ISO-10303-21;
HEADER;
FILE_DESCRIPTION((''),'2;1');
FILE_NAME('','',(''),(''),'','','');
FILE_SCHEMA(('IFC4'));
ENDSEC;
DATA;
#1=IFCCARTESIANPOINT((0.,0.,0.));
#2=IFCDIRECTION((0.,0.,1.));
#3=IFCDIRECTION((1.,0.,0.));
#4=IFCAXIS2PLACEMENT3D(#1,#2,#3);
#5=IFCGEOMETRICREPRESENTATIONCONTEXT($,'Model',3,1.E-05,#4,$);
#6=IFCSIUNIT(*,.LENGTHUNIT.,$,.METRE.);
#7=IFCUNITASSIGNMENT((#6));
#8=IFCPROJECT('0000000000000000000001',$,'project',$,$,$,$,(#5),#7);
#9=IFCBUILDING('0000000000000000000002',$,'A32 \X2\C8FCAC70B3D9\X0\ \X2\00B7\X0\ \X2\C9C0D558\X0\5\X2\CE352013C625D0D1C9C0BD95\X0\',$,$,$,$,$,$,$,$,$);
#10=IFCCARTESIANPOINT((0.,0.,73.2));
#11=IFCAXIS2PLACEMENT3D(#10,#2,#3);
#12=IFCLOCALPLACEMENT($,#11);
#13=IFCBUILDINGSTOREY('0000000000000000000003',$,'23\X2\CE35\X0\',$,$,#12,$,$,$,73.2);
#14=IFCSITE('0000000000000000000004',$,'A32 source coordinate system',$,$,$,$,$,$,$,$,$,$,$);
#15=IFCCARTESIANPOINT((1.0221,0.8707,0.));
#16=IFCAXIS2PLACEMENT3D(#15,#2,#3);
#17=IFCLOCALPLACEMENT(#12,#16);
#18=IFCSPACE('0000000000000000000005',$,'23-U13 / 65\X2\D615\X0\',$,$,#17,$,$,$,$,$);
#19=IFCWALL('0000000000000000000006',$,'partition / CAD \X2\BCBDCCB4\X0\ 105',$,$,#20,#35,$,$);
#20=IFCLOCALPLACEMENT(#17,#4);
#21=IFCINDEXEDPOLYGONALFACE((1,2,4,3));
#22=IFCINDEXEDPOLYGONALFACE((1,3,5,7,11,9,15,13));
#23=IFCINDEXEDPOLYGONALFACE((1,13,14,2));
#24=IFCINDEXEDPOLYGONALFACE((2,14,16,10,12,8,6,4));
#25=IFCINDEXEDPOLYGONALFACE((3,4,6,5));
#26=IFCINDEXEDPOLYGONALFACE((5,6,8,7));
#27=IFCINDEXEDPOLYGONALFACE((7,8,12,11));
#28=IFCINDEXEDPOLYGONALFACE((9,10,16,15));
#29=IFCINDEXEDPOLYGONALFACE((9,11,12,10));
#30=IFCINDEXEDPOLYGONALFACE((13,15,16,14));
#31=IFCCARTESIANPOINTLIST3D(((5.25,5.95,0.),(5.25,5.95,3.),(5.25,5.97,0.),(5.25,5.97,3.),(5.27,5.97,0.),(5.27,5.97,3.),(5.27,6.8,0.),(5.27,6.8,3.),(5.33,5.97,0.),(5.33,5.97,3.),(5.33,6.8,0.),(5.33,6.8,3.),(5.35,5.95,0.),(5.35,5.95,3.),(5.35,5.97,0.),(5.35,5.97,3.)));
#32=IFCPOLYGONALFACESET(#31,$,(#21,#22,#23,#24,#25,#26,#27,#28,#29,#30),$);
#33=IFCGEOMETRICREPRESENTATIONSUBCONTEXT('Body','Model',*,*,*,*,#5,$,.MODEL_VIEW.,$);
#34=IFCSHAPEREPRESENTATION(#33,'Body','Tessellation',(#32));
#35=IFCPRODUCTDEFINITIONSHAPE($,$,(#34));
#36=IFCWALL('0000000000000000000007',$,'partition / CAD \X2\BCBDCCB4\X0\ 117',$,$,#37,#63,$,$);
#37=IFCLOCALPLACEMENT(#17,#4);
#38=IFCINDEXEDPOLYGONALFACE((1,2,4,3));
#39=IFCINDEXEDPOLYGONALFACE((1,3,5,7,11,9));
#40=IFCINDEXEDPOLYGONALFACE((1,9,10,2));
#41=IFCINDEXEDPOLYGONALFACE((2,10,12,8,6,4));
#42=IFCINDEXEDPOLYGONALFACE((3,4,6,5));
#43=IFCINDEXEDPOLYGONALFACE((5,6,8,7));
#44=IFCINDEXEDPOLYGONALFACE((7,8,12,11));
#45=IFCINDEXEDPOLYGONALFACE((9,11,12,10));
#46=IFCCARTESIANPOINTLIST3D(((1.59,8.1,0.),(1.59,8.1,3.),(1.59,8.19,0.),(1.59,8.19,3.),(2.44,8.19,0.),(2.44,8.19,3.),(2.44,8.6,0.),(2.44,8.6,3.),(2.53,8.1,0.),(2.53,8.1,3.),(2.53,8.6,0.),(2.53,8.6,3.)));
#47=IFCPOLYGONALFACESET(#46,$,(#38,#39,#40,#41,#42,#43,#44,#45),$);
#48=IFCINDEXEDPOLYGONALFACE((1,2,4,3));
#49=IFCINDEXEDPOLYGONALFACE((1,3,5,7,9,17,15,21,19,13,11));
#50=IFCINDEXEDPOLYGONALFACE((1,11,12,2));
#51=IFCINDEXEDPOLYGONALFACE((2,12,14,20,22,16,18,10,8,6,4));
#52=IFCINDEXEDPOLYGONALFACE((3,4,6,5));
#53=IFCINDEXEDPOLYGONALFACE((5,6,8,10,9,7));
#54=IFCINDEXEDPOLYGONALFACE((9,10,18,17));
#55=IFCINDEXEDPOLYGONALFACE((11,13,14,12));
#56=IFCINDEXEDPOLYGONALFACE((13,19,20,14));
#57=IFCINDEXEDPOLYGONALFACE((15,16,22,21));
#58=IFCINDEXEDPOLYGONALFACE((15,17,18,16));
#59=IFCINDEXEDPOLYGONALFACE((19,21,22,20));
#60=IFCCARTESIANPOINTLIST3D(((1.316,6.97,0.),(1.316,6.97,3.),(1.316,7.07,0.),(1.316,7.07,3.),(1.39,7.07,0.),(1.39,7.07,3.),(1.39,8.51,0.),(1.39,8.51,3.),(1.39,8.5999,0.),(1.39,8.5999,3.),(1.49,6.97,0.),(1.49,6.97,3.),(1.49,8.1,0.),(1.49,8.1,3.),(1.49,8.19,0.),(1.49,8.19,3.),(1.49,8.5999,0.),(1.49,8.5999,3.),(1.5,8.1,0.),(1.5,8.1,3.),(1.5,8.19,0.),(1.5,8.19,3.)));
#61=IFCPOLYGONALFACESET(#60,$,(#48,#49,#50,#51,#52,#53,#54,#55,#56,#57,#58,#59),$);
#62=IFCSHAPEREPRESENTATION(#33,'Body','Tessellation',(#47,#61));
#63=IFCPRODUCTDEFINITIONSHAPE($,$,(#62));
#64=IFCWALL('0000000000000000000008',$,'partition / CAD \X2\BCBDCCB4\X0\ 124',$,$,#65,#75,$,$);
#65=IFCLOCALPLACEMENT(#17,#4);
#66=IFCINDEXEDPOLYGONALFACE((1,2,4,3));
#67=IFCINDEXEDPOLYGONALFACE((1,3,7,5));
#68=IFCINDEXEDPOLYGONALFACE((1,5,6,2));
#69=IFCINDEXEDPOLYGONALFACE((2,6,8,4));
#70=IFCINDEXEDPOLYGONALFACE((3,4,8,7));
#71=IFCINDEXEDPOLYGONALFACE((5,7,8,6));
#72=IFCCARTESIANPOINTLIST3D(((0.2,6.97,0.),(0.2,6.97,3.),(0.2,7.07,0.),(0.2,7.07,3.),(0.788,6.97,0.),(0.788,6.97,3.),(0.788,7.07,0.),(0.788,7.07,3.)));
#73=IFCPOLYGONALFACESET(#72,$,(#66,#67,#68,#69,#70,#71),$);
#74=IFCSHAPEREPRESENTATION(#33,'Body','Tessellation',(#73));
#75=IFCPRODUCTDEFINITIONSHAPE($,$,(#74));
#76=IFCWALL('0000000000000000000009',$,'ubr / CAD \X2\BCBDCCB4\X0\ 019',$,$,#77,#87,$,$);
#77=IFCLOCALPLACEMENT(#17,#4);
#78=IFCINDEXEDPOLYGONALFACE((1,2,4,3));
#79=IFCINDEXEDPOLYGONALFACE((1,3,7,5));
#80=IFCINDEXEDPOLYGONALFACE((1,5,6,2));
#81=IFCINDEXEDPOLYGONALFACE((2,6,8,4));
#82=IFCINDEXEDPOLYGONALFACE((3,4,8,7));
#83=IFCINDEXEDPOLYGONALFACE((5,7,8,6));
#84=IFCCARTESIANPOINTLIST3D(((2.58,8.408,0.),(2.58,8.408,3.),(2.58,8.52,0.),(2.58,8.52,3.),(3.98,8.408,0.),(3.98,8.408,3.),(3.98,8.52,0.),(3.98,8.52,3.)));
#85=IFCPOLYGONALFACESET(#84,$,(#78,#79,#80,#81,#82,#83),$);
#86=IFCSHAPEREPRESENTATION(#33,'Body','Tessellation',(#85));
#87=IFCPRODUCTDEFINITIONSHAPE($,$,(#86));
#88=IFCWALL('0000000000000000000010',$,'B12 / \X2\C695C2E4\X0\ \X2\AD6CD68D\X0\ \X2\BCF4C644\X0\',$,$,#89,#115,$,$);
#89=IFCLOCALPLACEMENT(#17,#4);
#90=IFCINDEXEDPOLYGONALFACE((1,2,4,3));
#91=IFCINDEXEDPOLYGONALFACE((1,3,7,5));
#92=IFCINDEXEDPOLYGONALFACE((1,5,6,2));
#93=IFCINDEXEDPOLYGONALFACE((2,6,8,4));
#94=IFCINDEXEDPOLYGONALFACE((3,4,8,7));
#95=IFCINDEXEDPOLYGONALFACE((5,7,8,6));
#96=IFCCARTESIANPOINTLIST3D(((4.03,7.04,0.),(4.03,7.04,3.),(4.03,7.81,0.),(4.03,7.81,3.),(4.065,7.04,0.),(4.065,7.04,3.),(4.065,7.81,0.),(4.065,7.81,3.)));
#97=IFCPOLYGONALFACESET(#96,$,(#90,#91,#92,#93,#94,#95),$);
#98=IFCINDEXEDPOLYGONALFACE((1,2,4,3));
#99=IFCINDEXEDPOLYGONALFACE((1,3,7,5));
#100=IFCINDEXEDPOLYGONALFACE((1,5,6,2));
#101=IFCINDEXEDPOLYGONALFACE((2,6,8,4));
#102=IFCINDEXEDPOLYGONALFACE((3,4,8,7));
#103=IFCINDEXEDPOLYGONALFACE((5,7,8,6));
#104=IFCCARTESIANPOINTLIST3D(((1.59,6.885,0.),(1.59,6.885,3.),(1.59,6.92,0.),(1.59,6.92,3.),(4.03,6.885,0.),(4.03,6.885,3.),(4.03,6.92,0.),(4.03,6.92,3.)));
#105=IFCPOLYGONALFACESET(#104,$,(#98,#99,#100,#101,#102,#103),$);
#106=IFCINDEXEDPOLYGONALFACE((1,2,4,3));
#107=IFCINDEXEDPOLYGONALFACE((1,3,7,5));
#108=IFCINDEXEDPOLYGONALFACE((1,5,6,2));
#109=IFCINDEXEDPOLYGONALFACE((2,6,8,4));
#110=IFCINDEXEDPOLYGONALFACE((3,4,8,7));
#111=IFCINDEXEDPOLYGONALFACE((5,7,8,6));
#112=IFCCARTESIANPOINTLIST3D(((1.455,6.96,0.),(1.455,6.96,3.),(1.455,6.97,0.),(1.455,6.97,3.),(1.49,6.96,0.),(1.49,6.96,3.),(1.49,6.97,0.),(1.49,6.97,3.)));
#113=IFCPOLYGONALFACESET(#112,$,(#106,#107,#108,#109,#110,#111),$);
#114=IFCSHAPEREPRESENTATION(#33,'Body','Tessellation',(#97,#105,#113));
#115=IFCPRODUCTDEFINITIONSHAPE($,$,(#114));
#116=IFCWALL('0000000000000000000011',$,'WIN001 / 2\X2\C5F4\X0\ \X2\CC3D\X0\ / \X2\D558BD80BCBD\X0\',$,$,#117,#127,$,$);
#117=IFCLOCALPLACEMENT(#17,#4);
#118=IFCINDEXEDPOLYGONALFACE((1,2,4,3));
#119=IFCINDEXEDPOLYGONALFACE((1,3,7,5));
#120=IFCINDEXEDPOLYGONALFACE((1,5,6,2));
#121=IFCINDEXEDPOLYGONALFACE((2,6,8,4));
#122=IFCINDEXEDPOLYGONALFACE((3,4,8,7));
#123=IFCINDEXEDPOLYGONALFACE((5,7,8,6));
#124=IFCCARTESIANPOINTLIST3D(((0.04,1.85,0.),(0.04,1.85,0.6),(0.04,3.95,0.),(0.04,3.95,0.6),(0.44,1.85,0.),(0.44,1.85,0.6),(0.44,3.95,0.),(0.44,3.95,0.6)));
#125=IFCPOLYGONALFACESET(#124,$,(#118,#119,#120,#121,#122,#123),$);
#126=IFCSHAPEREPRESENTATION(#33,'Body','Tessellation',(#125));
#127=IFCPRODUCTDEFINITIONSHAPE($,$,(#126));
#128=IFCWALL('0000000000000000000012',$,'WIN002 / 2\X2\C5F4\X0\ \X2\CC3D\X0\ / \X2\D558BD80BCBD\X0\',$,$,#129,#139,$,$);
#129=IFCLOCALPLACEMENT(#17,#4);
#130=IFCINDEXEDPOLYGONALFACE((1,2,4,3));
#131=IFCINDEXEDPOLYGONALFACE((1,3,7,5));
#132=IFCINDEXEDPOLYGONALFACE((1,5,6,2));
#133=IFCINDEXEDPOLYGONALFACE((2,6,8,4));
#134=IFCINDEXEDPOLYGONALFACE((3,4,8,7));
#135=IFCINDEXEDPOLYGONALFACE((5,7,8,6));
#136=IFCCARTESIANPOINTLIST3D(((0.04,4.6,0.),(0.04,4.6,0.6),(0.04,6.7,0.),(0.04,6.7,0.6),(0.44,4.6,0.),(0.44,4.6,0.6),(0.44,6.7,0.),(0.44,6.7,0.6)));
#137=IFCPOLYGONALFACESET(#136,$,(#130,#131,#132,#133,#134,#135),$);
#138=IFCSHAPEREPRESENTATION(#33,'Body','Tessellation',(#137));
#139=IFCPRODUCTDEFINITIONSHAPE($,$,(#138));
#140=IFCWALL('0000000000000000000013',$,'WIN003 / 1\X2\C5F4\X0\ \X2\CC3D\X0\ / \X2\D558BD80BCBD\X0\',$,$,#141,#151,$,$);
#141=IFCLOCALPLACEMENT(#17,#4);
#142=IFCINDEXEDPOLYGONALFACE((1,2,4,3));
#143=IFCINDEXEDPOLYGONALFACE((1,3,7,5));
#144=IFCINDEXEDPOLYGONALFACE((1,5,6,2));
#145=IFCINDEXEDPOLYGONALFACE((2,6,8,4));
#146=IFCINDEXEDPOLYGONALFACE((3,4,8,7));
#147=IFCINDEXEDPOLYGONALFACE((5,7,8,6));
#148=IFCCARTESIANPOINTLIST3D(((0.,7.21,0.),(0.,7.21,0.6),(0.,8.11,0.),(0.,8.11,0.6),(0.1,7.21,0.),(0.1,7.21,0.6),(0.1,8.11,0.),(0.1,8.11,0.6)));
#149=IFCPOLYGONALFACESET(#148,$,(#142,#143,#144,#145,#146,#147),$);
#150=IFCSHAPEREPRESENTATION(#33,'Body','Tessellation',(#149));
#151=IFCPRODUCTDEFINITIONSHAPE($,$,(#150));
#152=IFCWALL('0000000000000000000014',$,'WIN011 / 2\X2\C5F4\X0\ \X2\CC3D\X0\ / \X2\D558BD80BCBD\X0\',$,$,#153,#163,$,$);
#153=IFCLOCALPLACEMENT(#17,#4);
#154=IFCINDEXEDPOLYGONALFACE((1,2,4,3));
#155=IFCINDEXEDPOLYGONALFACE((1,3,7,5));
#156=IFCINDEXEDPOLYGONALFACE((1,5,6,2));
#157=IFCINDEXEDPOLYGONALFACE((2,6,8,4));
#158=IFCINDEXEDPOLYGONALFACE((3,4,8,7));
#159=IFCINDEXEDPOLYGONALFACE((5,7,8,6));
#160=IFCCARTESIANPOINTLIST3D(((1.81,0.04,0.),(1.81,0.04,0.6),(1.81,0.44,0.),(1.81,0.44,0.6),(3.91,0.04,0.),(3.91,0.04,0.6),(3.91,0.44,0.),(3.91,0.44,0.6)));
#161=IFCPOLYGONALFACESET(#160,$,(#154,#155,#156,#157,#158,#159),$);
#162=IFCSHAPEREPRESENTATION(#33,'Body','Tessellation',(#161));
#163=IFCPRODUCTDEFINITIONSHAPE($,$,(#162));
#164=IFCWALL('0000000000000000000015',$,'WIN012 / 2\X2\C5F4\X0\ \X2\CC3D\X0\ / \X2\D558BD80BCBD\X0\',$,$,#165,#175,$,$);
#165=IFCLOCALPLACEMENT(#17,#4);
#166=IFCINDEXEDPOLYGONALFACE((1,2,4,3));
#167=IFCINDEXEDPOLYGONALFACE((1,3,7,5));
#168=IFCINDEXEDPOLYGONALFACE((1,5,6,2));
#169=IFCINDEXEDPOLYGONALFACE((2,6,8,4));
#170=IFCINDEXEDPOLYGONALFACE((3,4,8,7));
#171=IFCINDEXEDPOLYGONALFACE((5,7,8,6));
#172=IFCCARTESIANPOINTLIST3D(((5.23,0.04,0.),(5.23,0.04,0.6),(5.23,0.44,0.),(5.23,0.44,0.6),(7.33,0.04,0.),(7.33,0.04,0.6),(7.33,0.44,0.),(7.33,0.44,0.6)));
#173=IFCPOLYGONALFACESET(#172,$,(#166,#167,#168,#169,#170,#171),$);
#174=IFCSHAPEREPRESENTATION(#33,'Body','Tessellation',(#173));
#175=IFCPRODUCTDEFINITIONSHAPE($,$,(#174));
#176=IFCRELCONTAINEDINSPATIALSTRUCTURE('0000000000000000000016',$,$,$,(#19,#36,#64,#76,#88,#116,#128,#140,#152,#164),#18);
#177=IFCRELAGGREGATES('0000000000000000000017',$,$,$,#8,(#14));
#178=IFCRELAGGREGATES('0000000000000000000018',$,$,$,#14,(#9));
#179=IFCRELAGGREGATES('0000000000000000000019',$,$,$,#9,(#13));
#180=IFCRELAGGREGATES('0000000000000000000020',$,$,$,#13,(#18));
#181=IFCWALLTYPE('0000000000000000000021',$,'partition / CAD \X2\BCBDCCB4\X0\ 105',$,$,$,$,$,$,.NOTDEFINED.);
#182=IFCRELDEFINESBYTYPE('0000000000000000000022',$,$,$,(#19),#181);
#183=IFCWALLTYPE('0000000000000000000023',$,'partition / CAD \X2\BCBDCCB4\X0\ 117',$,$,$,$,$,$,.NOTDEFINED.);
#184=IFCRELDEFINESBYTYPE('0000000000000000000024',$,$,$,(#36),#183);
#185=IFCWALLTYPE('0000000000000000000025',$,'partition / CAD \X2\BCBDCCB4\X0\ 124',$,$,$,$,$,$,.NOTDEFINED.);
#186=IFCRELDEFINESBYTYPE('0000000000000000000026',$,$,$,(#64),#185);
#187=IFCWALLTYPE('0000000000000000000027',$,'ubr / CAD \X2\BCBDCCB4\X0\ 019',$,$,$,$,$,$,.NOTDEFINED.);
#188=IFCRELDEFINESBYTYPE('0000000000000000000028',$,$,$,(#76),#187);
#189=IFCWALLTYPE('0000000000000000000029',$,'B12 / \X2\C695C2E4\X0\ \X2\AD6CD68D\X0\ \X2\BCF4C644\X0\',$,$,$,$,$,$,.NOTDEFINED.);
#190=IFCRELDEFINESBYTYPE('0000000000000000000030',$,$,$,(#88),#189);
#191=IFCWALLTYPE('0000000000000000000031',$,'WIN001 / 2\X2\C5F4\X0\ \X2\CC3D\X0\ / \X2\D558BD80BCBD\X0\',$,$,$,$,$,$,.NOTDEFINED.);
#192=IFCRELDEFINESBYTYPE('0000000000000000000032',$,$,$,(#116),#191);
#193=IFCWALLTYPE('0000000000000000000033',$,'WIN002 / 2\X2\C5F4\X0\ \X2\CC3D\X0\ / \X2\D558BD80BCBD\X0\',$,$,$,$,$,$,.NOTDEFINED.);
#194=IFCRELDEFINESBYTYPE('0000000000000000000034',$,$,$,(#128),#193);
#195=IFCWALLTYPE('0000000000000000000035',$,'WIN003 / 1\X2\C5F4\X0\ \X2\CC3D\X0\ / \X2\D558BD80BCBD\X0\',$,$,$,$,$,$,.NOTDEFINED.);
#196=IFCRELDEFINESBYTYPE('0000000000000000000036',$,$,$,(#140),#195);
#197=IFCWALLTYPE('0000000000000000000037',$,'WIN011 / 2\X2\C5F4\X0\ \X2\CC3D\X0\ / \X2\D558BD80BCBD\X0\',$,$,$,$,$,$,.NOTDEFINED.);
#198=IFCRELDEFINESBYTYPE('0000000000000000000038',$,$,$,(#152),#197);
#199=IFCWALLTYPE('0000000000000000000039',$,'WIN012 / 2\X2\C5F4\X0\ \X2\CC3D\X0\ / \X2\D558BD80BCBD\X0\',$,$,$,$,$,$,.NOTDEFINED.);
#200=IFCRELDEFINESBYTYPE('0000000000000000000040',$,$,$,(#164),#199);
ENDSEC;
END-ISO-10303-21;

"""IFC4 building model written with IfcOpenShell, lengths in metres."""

from ifc_helpers import new_model, si_unit, frame, origin, origin_with_axes, place, context, subcontext, project, spatial, polyline, outline, extrude, source, transform, mapped, type_object, type_shapes, element, save


model = new_model("IFC4")

# Units and contexts
model_context = context("Model", 3, precision=1e-05, world=origin_with_axes())
body_context = subcontext(model_context, "Body", "Model", "MODEL_VIEW")
ifc_project = project(units=[si_unit("LENGTHUNIT", "METRE")], contexts=[model_context])

# Site, building, storey, space
site = spatial("IfcSite", under=ifc_project, Name="A32 source coordinate system")
building = spatial("IfcBuilding", under=site, Name="A32 주거동 · 지하5층–옥탑지붕")
storey_placement = place(None, frame((0.0, 0.0, 73.2), z_axis=(0.0, 0.0, 1.0), x_axis=(1.0, 0.0, 0.0)))
storey = spatial("IfcBuildingStorey", under=building, at=storey_placement, Name="23층", Elevation=73.2)
space_placement = place(storey_placement, frame((1.0221, 0.8707, 0.0), z_axis=(0.0, 0.0, 1.0), x_axis=(1.0, 0.0, 0.0)))
space = spatial("IfcSpace", under=storey, at=space_placement, Name="23-U13 / 65형")

# Walls
wall_type_1 = type_object("IfcWallType", Name="partition / CAD 벽체 105", PredefinedType="NOTDEFINED")
shared_shape_1 = source(origin(), body_context, "Body", "SweptSolid", [
    extrude(outline(polyline([(5.25, 5.97), (5.27, 5.97), (5.27, 6.8), (5.33, 6.8), (5.33, 5.97), (5.35, 5.97), (5.35, 5.95), (5.25, 5.95), (5.25, 5.97)])), origin(), (0.0, 0.0, 1.0), 3.0),
])
type_shapes(wall_type_1, [shared_shape_1])
wall_1_placement = place(space_placement, origin_with_axes())
element("IfcWall", 1, at=wall_1_placement, inside=space, type_object=wall_type_1, Name="partition / CAD 벽체 105", context=body_context, shape_type="MappedRepresentation", body=[
    mapped(shared_shape_1, transform((0.0, 0.0, 0.0), scale=1.0)),
])
wall_type_2 = type_object("IfcWallType", Name="partition / CAD 벽체 117", PredefinedType="NOTDEFINED")
shared_shape_2 = source(origin(), body_context, "Body", "SweptSolid", [
    extrude(outline(polyline([(2.53, 8.1), (1.59, 8.1), (1.59, 8.19), (2.44, 8.19), (2.44, 8.6), (2.53, 8.6), (2.53, 8.1)])), origin(), (0.0, 0.0, 1.0), 3.0),
    extrude(outline(polyline([(1.49, 8.1), (1.49, 6.97), (1.316, 6.97), (1.316, 7.07), (1.39, 7.07), (1.39, 8.51), (1.39, 8.5999), (1.49, 8.5999), (1.49, 8.19), (1.5, 8.19), (1.5, 8.1), (1.49, 8.1)])), origin(), (0.0, 0.0, 1.0), 3.0),
])
type_shapes(wall_type_2, [shared_shape_2])
wall_2_placement = place(space_placement, origin_with_axes())
element("IfcWall", 2, at=wall_2_placement, inside=space, type_object=wall_type_2, Name="partition / CAD 벽체 117", context=body_context, shape_type="MappedRepresentation", body=[
    mapped(shared_shape_2, transform((0.0, 0.0, 0.0), scale=1.0)),
])
wall_type_3 = type_object("IfcWallType", Name="partition / CAD 벽체 124", PredefinedType="NOTDEFINED")
shared_shape_3 = source(origin(), body_context, "Body", "SweptSolid", [
    extrude(outline(polyline([(0.788, 7.07), (0.788, 6.97), (0.2, 6.97), (0.2, 7.07), (0.788, 7.07)])), origin(), (0.0, 0.0, 1.0), 3.0),
])
type_shapes(wall_type_3, [shared_shape_3])
wall_3_placement = place(space_placement, origin_with_axes())
element("IfcWall", 3, at=wall_3_placement, inside=space, type_object=wall_type_3, Name="partition / CAD 벽체 124", context=body_context, shape_type="MappedRepresentation", body=[
    mapped(shared_shape_3, transform((0.0, 0.0, 0.0), scale=1.0)),
])
wall_type_4 = type_object("IfcWallType", Name="ubr / CAD 벽체 019", PredefinedType="NOTDEFINED")
shared_shape_4 = source(origin(), body_context, "Body", "SweptSolid", [
    extrude(outline(polyline([(3.98, 8.408), (2.58, 8.408), (2.58, 8.52), (3.98, 8.52), (3.98, 8.408)])), origin(), (0.0, 0.0, 1.0), 3.0),
])
type_shapes(wall_type_4, [shared_shape_4])
wall_4_placement = place(space_placement, origin_with_axes())
element("IfcWall", 4, at=wall_4_placement, inside=space, type_object=wall_type_4, Name="ubr / CAD 벽체 019", context=body_context, shape_type="MappedRepresentation", body=[
    mapped(shared_shape_4, transform((0.0, 0.0, 0.0), scale=1.0)),
])
wall_type_5 = type_object("IfcWallType", Name="B12 / 욕실 구획 보완", PredefinedType="NOTDEFINED")
shared_shape_5 = source(origin(), body_context, "Body", "SweptSolid", [
    extrude(outline(polyline([(4.065, 7.04), (4.03, 7.04), (4.03, 7.81), (4.065, 7.81), (4.065, 7.04)])), origin(), (0.0, 0.0, 1.0), 3.0),
    extrude(outline(polyline([(1.59, 6.92), (4.03, 6.92), (4.03, 6.885), (1.59, 6.885), (1.59, 6.92)])), origin(), (0.0, 0.0, 1.0), 3.0),
    extrude(outline(polyline([(1.455, 6.97), (1.49, 6.97), (1.49, 6.96), (1.455, 6.96), (1.455, 6.97)])), origin(), (0.0, 0.0, 1.0), 3.0),
])
type_shapes(wall_type_5, [shared_shape_5])
wall_5_placement = place(space_placement, origin_with_axes())
element("IfcWall", 5, at=wall_5_placement, inside=space, type_object=wall_type_5, Name="B12 / 욕실 구획 보완", context=body_context, shape_type="MappedRepresentation", body=[
    mapped(shared_shape_5, transform((0.0, 0.0, 0.0), scale=1.0)),
])
wall_type_6 = type_object("IfcWallType", Name="WIN001 / 2열 창 / 하부벽", PredefinedType="NOTDEFINED")
shared_shape_6 = source(origin(), body_context, "Body", "SweptSolid", [
    extrude(outline(polyline([(0.04, 3.95), (0.44, 3.95), (0.44, 1.85), (0.04, 1.85), (0.04, 3.95)])), origin(), (0.0, 0.0, 1.0), 0.6),
])
type_shapes(wall_type_6, [shared_shape_6])
wall_6_placement = place(space_placement, origin_with_axes())
element("IfcWall", 6, at=wall_6_placement, inside=space, type_object=wall_type_6, Name="WIN001 / 2열 창 / 하부벽", context=body_context, shape_type="MappedRepresentation", body=[
    mapped(shared_shape_6, transform((0.0, 0.0, 0.0), scale=1.0)),
])
wall_type_7 = type_object("IfcWallType", Name="WIN002 / 2열 창 / 하부벽", PredefinedType="NOTDEFINED")
shared_shape_7 = source(origin(), body_context, "Body", "SweptSolid", [
    extrude(outline(polyline([(0.04, 6.7), (0.44, 6.7), (0.44, 4.6), (0.04, 4.6), (0.04, 6.7)])), origin(), (0.0, 0.0, 1.0), 0.6),
])
type_shapes(wall_type_7, [shared_shape_7])
wall_7_placement = place(space_placement, origin_with_axes())
element("IfcWall", 7, at=wall_7_placement, inside=space, type_object=wall_type_7, Name="WIN002 / 2열 창 / 하부벽", context=body_context, shape_type="MappedRepresentation", body=[
    mapped(shared_shape_7, transform((0.0, 0.0, 0.0), scale=1.0)),
])
wall_type_8 = type_object("IfcWallType", Name="WIN003 / 1열 창 / 하부벽", PredefinedType="NOTDEFINED")
shared_shape_8 = source(origin(), body_context, "Body", "SweptSolid", [
    extrude(outline(polyline([(0.0, 8.11), (0.1, 8.11), (0.1, 7.21), (0.0, 7.21), (0.0, 8.11)])), origin(), (0.0, 0.0, 1.0), 0.6),
])
type_shapes(wall_type_8, [shared_shape_8])
wall_8_placement = place(space_placement, origin_with_axes())
element("IfcWall", 8, at=wall_8_placement, inside=space, type_object=wall_type_8, Name="WIN003 / 1열 창 / 하부벽", context=body_context, shape_type="MappedRepresentation", body=[
    mapped(shared_shape_8, transform((0.0, 0.0, 0.0), scale=1.0)),
])
wall_type_9 = type_object("IfcWallType", Name="WIN011 / 2열 창 / 하부벽", PredefinedType="NOTDEFINED")
shared_shape_9 = source(origin(), body_context, "Body", "SweptSolid", [
    extrude(outline(polyline([(1.81, 0.44), (3.91, 0.44), (3.91, 0.04), (1.81, 0.04), (1.81, 0.44)])), origin(), (0.0, 0.0, 1.0), 0.6),
])
type_shapes(wall_type_9, [shared_shape_9])
wall_9_placement = place(space_placement, origin_with_axes())
element("IfcWall", 9, at=wall_9_placement, inside=space, type_object=wall_type_9, Name="WIN011 / 2열 창 / 하부벽", context=body_context, shape_type="MappedRepresentation", body=[
    mapped(shared_shape_9, transform((0.0, 0.0, 0.0), scale=1.0)),
])
wall_type_10 = type_object("IfcWallType", Name="WIN012 / 2열 창 / 하부벽", PredefinedType="NOTDEFINED")
shared_shape_10 = source(origin(), body_context, "Body", "SweptSolid", [
    extrude(outline(polyline([(5.23, 0.44), (7.33, 0.44), (7.33, 0.04), (5.23, 0.04), (5.23, 0.44)])), origin(), (0.0, 0.0, 1.0), 0.6),
])
type_shapes(wall_type_10, [shared_shape_10])
wall_10_placement = place(space_placement, origin_with_axes())
element("IfcWall", 10, at=wall_10_placement, inside=space, type_object=wall_type_10, Name="WIN012 / 2열 창 / 하부벽", context=body_context, shape_type="MappedRepresentation", body=[
    mapped(shared_shape_10, transform((0.0, 0.0, 0.0), scale=1.0)),
])

save(model, "model.ifc")
